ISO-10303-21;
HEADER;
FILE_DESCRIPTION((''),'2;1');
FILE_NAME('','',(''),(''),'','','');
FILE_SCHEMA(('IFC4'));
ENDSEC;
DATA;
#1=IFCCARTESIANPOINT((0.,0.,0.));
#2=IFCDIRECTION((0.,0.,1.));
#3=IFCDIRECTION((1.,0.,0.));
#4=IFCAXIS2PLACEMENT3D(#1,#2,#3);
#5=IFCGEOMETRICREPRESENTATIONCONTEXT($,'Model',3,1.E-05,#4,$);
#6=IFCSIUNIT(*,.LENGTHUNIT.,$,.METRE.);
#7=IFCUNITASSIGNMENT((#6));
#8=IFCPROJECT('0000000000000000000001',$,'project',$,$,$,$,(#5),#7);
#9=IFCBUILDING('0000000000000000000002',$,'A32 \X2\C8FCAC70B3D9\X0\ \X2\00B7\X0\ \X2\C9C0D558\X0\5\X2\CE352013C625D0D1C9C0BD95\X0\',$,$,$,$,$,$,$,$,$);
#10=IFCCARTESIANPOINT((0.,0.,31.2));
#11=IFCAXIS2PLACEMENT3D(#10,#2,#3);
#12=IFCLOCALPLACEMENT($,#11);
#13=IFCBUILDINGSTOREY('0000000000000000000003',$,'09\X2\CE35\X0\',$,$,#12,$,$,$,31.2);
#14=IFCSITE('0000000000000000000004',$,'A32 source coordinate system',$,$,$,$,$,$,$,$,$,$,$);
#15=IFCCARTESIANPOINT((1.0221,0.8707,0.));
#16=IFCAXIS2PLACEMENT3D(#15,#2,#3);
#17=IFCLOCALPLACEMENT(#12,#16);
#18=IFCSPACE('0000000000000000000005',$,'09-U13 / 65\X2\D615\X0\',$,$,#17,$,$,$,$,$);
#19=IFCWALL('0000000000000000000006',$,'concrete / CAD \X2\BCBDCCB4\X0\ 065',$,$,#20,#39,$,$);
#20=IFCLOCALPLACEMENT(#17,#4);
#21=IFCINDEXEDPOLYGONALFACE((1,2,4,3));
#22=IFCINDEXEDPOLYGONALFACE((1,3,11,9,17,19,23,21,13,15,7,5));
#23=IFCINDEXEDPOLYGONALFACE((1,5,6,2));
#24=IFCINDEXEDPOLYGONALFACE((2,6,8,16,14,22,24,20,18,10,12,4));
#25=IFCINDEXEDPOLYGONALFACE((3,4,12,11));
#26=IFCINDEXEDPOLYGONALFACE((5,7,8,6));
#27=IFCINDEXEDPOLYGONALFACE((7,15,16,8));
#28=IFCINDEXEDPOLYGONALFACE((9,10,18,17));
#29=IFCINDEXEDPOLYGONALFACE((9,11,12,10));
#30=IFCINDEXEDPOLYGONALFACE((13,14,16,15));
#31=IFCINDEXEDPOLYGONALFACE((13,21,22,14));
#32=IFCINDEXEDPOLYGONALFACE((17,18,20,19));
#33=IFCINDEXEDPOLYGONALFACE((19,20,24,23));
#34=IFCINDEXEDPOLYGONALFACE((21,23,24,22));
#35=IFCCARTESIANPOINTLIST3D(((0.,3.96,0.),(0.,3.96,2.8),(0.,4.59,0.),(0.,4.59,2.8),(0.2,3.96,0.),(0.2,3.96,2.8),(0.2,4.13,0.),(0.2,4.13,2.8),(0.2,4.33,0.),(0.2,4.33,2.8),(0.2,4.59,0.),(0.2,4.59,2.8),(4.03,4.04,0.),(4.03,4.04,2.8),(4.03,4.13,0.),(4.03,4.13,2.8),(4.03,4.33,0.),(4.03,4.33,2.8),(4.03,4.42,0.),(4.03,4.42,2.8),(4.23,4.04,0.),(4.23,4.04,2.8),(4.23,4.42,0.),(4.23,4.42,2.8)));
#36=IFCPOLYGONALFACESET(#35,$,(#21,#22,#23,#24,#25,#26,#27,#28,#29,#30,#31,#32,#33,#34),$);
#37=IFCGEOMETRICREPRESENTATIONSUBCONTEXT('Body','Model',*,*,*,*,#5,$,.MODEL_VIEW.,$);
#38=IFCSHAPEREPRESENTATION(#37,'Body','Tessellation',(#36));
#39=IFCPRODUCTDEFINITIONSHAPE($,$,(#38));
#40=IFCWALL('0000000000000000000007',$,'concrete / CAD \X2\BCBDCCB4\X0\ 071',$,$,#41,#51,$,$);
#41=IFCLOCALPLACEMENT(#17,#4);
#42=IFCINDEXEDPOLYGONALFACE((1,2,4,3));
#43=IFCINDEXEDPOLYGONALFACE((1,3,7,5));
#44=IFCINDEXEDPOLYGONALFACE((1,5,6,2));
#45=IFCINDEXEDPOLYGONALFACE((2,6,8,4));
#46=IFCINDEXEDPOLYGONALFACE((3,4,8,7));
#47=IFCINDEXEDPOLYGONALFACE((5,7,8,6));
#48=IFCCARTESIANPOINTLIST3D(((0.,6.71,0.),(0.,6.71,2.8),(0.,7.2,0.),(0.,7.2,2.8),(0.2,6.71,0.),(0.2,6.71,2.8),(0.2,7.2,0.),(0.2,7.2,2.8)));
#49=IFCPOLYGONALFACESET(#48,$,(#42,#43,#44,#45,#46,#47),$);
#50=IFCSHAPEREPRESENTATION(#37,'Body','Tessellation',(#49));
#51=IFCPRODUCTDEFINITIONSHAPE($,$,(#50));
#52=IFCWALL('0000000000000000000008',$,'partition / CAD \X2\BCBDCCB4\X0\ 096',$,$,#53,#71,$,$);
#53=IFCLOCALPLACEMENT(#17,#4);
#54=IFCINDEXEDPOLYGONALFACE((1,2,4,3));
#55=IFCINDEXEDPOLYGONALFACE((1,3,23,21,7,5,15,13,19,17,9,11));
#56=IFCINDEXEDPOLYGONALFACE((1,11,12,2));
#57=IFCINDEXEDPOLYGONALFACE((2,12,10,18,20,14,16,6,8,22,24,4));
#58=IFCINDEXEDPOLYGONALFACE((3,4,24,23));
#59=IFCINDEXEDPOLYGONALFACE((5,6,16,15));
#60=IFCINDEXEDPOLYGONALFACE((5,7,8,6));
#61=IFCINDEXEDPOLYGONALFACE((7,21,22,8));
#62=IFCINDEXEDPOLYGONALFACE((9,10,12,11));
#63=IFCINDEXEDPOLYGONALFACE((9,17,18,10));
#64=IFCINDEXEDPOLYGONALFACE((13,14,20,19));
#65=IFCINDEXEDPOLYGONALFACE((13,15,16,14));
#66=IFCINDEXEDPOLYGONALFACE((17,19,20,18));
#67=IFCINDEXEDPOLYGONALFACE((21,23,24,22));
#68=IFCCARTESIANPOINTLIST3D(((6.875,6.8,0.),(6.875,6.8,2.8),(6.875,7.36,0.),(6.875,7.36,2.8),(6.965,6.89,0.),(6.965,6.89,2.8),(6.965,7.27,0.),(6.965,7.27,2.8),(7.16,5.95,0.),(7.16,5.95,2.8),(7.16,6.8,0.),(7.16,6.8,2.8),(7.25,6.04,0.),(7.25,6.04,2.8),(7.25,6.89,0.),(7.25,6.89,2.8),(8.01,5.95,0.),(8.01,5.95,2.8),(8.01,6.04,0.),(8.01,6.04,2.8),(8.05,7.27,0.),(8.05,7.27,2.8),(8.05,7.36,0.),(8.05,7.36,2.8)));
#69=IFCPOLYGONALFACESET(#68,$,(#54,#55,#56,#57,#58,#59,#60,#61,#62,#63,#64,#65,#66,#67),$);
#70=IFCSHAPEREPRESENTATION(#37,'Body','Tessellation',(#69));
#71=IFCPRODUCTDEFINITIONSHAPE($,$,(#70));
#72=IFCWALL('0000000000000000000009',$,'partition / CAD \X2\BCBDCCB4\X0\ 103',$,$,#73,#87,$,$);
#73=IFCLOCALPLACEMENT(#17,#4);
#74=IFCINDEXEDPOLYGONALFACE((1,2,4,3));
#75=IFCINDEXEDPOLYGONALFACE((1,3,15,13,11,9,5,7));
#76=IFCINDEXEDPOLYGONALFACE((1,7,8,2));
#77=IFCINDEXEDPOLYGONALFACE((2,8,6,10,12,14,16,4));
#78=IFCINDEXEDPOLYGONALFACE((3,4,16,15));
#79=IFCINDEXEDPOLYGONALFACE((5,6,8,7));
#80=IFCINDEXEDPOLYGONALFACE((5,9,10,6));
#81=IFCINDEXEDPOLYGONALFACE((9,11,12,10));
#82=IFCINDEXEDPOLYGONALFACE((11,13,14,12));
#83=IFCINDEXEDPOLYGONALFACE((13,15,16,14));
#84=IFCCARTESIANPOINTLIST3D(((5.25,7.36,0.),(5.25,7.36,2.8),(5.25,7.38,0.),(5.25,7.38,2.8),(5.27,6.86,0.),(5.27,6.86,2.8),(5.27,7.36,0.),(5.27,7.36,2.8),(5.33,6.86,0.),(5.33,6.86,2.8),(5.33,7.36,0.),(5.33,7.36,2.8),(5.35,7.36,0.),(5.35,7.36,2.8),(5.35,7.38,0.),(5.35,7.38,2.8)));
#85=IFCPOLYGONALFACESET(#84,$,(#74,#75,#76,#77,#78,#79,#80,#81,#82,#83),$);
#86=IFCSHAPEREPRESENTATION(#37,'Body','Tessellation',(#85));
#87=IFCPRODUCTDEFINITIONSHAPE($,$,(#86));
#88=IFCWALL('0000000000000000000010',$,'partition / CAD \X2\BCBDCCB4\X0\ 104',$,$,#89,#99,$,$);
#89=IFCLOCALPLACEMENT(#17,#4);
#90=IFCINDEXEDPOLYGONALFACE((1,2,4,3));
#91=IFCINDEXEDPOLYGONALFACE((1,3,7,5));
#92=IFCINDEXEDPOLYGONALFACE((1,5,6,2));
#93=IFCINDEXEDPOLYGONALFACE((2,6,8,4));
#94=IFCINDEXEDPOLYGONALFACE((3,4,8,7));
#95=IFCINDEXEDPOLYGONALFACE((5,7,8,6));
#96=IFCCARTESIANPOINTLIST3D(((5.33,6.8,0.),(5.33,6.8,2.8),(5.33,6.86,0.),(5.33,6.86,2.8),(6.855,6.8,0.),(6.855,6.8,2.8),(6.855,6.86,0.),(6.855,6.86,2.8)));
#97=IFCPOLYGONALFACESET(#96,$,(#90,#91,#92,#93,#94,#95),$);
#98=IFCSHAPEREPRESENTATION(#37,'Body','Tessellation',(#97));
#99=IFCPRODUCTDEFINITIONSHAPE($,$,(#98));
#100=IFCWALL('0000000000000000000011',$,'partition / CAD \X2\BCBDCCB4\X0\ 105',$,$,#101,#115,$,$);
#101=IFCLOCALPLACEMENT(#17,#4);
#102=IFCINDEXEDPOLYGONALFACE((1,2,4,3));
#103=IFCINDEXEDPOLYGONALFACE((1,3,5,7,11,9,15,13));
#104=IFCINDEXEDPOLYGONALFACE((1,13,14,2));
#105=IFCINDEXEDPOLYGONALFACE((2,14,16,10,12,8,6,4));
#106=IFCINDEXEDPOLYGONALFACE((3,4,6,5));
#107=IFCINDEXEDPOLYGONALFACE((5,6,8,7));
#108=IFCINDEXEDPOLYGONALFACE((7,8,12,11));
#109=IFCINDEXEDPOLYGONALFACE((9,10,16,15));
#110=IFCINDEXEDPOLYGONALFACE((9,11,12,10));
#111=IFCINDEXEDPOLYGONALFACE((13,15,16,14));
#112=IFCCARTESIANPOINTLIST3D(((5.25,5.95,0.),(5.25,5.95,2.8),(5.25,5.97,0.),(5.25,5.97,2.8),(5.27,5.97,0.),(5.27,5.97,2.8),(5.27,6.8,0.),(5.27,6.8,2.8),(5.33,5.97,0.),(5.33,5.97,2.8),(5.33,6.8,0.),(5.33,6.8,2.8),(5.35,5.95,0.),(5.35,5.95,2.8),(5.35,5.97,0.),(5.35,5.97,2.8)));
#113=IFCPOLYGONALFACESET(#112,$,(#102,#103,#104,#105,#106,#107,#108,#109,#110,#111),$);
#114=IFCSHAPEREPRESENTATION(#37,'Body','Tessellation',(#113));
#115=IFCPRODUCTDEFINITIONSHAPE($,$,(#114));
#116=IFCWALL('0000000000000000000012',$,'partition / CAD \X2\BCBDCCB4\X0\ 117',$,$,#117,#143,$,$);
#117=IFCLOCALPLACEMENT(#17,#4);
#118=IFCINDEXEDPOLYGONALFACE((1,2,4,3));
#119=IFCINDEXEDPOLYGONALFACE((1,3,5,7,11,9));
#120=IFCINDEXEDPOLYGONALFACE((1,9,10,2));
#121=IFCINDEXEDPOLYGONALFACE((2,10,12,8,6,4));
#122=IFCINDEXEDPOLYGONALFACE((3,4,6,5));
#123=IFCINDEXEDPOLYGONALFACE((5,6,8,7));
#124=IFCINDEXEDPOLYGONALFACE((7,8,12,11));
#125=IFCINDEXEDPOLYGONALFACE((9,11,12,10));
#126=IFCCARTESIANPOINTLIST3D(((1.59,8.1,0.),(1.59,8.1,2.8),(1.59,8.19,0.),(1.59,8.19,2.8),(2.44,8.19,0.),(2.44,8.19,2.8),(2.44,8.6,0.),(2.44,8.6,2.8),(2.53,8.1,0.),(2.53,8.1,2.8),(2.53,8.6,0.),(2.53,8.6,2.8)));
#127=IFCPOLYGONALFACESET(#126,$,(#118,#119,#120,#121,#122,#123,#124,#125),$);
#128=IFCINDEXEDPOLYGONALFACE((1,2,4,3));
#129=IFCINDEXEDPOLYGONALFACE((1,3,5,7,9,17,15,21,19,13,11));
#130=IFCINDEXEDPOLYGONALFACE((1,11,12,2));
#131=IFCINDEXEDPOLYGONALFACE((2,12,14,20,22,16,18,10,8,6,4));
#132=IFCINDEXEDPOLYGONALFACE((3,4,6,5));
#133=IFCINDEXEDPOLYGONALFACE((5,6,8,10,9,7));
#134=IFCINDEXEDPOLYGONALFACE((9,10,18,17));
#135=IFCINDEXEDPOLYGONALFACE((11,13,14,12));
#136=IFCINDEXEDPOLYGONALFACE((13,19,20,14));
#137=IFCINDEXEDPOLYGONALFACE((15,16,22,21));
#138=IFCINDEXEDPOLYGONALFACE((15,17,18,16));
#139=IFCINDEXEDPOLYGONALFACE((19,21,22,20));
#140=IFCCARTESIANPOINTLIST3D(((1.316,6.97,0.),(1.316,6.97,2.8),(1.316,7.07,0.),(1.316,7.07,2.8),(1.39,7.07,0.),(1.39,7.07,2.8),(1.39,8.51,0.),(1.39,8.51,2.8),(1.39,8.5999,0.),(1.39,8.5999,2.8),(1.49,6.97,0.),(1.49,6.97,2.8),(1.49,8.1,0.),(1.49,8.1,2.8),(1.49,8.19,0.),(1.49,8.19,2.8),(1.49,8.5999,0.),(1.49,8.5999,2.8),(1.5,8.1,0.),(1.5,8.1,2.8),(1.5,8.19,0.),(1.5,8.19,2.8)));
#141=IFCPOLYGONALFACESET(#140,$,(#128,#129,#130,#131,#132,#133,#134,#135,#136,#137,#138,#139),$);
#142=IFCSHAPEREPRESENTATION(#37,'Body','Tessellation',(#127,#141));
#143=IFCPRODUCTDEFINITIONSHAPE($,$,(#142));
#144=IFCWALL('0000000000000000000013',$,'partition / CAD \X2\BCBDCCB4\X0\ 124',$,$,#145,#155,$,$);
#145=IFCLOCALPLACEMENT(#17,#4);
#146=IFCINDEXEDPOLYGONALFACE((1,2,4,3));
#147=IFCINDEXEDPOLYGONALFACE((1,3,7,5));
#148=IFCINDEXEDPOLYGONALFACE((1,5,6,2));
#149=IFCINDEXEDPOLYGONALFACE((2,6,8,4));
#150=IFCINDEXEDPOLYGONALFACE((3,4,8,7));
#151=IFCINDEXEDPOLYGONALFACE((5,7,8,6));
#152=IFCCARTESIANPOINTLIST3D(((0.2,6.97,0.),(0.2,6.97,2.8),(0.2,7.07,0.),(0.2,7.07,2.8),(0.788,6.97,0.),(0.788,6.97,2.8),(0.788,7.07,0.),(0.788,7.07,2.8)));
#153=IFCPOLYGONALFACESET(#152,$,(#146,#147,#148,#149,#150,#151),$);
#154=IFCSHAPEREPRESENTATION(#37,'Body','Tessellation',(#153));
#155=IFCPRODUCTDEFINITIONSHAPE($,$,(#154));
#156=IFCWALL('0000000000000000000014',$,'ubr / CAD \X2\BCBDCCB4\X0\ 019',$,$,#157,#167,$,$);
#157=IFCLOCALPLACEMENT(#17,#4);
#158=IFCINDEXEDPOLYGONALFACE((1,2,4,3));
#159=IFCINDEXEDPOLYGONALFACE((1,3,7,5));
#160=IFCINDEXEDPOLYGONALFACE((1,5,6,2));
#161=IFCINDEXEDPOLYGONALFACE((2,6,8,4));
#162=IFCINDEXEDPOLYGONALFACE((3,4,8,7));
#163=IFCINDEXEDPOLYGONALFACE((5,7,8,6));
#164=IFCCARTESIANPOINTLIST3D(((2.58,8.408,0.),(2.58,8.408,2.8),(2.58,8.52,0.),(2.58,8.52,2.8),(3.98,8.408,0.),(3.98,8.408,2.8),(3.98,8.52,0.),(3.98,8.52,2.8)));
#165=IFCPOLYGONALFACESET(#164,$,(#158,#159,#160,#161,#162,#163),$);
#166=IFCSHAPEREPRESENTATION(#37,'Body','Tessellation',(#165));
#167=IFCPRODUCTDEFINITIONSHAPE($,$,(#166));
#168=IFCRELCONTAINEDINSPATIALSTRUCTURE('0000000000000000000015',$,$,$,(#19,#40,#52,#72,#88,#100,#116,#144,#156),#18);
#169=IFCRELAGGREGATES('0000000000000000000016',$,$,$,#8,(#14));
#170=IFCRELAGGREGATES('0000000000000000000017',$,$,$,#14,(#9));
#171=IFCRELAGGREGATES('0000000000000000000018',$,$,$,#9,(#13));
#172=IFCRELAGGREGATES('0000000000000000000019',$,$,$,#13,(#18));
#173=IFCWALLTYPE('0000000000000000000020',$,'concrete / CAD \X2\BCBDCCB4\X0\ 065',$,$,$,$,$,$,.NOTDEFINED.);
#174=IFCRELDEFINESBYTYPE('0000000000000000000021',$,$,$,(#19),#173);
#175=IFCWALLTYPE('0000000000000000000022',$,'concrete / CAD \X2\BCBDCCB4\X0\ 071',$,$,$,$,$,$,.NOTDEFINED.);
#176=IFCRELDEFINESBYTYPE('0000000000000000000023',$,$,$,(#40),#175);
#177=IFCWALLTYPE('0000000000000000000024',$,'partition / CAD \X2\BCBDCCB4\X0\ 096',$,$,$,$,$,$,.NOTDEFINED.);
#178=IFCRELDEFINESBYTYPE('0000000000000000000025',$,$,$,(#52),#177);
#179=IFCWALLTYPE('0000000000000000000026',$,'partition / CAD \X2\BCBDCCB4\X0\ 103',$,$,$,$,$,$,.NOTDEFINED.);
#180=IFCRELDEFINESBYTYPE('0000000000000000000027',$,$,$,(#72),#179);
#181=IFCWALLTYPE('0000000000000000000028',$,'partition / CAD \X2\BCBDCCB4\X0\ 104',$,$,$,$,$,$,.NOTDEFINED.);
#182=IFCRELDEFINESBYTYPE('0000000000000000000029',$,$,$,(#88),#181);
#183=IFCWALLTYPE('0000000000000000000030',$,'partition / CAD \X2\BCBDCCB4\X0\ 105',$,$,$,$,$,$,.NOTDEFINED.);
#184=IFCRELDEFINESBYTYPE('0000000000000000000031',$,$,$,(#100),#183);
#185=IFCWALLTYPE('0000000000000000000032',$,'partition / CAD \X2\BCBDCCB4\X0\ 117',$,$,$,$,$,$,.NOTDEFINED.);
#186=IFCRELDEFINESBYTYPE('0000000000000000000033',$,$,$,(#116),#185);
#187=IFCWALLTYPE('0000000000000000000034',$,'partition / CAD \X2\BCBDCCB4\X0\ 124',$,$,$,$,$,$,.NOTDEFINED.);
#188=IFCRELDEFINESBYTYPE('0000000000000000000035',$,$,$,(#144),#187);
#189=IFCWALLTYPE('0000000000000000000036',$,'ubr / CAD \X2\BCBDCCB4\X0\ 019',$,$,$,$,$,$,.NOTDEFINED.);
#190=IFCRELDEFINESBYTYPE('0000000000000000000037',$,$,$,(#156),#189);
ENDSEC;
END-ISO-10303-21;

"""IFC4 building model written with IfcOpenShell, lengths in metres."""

from ifc_helpers import new_model, si_unit, frame, origin, origin_with_axes, place, context, subcontext, project, spatial, polyline, outline, extrude, source, transform, mapped, type_object, type_shapes, element, save


model = new_model("IFC4")

# Units and contexts
model_context = context("Model", 3, precision=1e-05, world=origin_with_axes())
body_context = subcontext(model_context, "Body", "Model", "MODEL_VIEW")
ifc_project = project(units=[si_unit("LENGTHUNIT", "METRE")], contexts=[model_context])

# Site, building, storey, space
storey_placement = place(None, frame((0.0, 0.0, 31.2), z_axis=(0.0, 0.0, 1.0), x_axis=(1.0, 0.0, 0.0)))
space_placement = place(storey_placement, frame((1.0221, 0.8707, 0.0), z_axis=(0.0, 0.0, 1.0), x_axis=(1.0, 0.0, 0.0)))
site = spatial("IfcSite", under=ifc_project, Name="A32 source coordinate system")
building = spatial("IfcBuilding", under=site, Name="A32 주거동 · 지하5층–옥탑지붕")
storey = spatial("IfcBuildingStorey", under=building, at=storey_placement, Name="09층", Elevation=31.2)
space = spatial("IfcSpace", under=storey, at=space_placement, Name="09-U13 / 65형")

# Walls
wall_type_1 = type_object("IfcWallType", Name="concrete / CAD 벽체 065", PredefinedType="NOTDEFINED")
shared_shape_1 = source(origin(), body_context, "Body", "SweptSolid", [
    extrude(outline(polyline([(0.2, 4.59), (0.2, 4.33), (4.03, 4.33), (4.03, 4.42), (4.23, 4.42), (4.23, 4.04), (4.03, 4.04), (4.03, 4.13), (0.2, 4.13), (0.2, 3.96), (0.0, 3.96), (0.0, 4.59), (0.2, 4.59)])), origin(), (0.0, 0.0, 1.0), 2.8),
])
type_shapes(wall_type_1, [shared_shape_1])
wall_1_placement = place(space_placement, origin_with_axes())
element("IfcWall", 1, at=wall_1_placement, inside=space, type_object=wall_type_1, Name="concrete / CAD 벽체 065", context=body_context, shape_type="MappedRepresentation", body=[
    mapped(shared_shape_1, transform((0.0, 0.0, 0.0), scale=1.0)),
])
wall_type_2 = type_object("IfcWallType", Name="concrete / CAD 벽체 071", PredefinedType="NOTDEFINED")
shared_shape_2 = source(origin(), body_context, "Body", "SweptSolid", [
    extrude(outline(polyline([(0.2, 6.71), (0.0, 6.71), (0.0, 7.2), (0.2, 7.2), (0.2, 6.71)])), origin(), (0.0, 0.0, 1.0), 2.8),
])
type_shapes(wall_type_2, [shared_shape_2])
wall_2_placement = place(space_placement, origin_with_axes())
element("IfcWall", 2, at=wall_2_placement, inside=space, type_object=wall_type_2, Name="concrete / CAD 벽체 071", context=body_context, shape_type="MappedRepresentation", body=[
    mapped(shared_shape_2, transform((0.0, 0.0, 0.0), scale=1.0)),
])
wall_type_3 = type_object("IfcWallType", Name="partition / CAD 벽체 096", PredefinedType="NOTDEFINED")
shared_shape_3 = source(origin(), body_context, "Body", "SweptSolid", [
    extrude(outline(polyline([(7.25, 6.04), (8.01, 6.04), (8.01, 5.95), (7.16, 5.95), (7.16, 6.8), (6.875, 6.8), (6.875, 7.36), (8.05, 7.36), (8.05, 7.27), (6.965, 7.27), (6.965, 6.89), (7.25, 6.89), (7.25, 6.04)])), origin(), (0.0, 0.0, 1.0), 2.8),
])
type_shapes(wall_type_3, [shared_shape_3])
wall_3_placement = place(space_placement, origin_with_axes())
element("IfcWall", 3, at=wall_3_placement, inside=space, type_object=wall_type_3, Name="partition / CAD 벽체 096", context=body_context, shape_type="MappedRepresentation", body=[
    mapped(shared_shape_3, transform((0.0, 0.0, 0.0), scale=1.0)),
])
wall_type_4 = type_object("IfcWallType", Name="partition / CAD 벽체 103", PredefinedType="NOTDEFINED")
shared_shape_4 = source(origin(), body_context, "Body", "SweptSolid", [
    extrude(outline(polyline([(5.27, 7.36), (5.25, 7.36), (5.25, 7.38), (5.35, 7.38), (5.35, 7.36), (5.33, 7.36), (5.33, 6.86), (5.27, 6.86), (5.27, 7.36)])), origin(), (0.0, 0.0, 1.0), 2.8),
])
type_shapes(wall_type_4, [shared_shape_4])
wall_4_placement = place(space_placement, origin_with_axes())
element("IfcWall", 4, at=wall_4_placement, inside=space, type_object=wall_type_4, Name="partition / CAD 벽체 103", context=body_context, shape_type="MappedRepresentation", body=[
    mapped(shared_shape_4, transform((0.0, 0.0, 0.0), scale=1.0)),
])
wall_type_5 = type_object("IfcWallType", Name="partition / CAD 벽체 104", PredefinedType="NOTDEFINED")
shared_shape_5 = source(origin(), body_context, "Body", "SweptSolid", [
    extrude(outline(polyline([(6.855, 6.86), (6.855, 6.8), (5.33, 6.8), (5.33, 6.86), (6.855, 6.86)])), origin(), (0.0, 0.0, 1.0), 2.8),
])
type_shapes(wall_type_5, [shared_shape_5])
wall_5_placement = place(space_placement, origin_with_axes())
element("IfcWall", 5, at=wall_5_placement, inside=space, type_object=wall_type_5, Name="partition / CAD 벽체 104", context=body_context, shape_type="MappedRepresentation", body=[
    mapped(shared_shape_5, transform((0.0, 0.0, 0.0), scale=1.0)),
])
wall_type_6 = type_object("IfcWallType", Name="partition / CAD 벽체 105", PredefinedType="NOTDEFINED")
shared_shape_6 = source(origin(), body_context, "Body", "SweptSolid", [
    extrude(outline(polyline([(5.25, 5.97), (5.27, 5.97), (5.27, 6.8), (5.33, 6.8), (5.33, 5.97), (5.35, 5.97), (5.35, 5.95), (5.25, 5.95), (5.25, 5.97)])), origin(), (0.0, 0.0, 1.0), 2.8),
])
type_shapes(wall_type_6, [shared_shape_6])
wall_6_placement = place(space_placement, origin_with_axes())
element("IfcWall", 6, at=wall_6_placement, inside=space, type_object=wall_type_6, Name="partition / CAD 벽체 105", context=body_context, shape_type="MappedRepresentation", body=[
    mapped(shared_shape_6, transform((0.0, 0.0, 0.0), scale=1.0)),
])
wall_type_7 = type_object("IfcWallType", Name="partition / CAD 벽체 117", PredefinedType="NOTDEFINED")
shared_shape_7 = source(origin(), body_context, "Body", "SweptSolid", [
    extrude(outline(polyline([(2.53, 8.1), (1.59, 8.1), (1.59, 8.19), (2.44, 8.19), (2.44, 8.6), (2.53, 8.6), (2.53, 8.1)])), origin(), (0.0, 0.0, 1.0), 2.8),
    extrude(outline(polyline([(1.49, 8.1), (1.49, 6.97), (1.316, 6.97), (1.316, 7.07), (1.39, 7.07), (1.39, 8.51), (1.39, 8.5999), (1.49, 8.5999), (1.49, 8.19), (1.5, 8.19), (1.5, 8.1), (1.49, 8.1)])), origin(), (0.0, 0.0, 1.0), 2.8),
])
type_shapes(wall_type_7, [shared_shape_7])
wall_7_placement = place(space_placement, origin_with_axes())
element("IfcWall", 7, at=wall_7_placement, inside=space, type_object=wall_type_7, Name="partition / CAD 벽체 117", context=body_context, shape_type="MappedRepresentation", body=[
    mapped(shared_shape_7, transform((0.0, 0.0, 0.0), scale=1.0)),
])
wall_type_8 = type_object("IfcWallType", Name="partition / CAD 벽체 124", PredefinedType="NOTDEFINED")
shared_shape_8 = source(origin(), body_context, "Body", "SweptSolid", [
    extrude(outline(polyline([(0.788, 7.07), (0.788, 6.97), (0.2, 6.97), (0.2, 7.07), (0.788, 7.07)])), origin(), (0.0, 0.0, 1.0), 2.8),
])
type_shapes(wall_type_8, [shared_shape_8])
wall_8_placement = place(space_placement, origin_with_axes())
element("IfcWall", 8, at=wall_8_placement, inside=space, type_object=wall_type_8, Name="partition / CAD 벽체 124", context=body_context, shape_type="MappedRepresentation", body=[
    mapped(shared_shape_8, transform((0.0, 0.0, 0.0), scale=1.0)),
])
wall_type_9 = type_object("IfcWallType", Name="ubr / CAD 벽체 019", PredefinedType="NOTDEFINED")
shared_shape_9 = source(origin(), body_context, "Body", "SweptSolid", [
    extrude(outline(polyline([(3.98, 8.408), (2.58, 8.408), (2.58, 8.52), (3.98, 8.52), (3.98, 8.408)])), origin(), (0.0, 0.0, 1.0), 2.8),
])
type_shapes(wall_type_9, [shared_shape_9])
wall_9_placement = place(space_placement, origin_with_axes())
element("IfcWall", 9, at=wall_9_placement, inside=space, type_object=wall_type_9, Name="ubr / CAD 벽체 019", context=body_context, shape_type="MappedRepresentation", body=[
    mapped(shared_shape_9, transform((0.0, 0.0, 0.0), scale=1.0)),
])

save(model, "model.ifc")
